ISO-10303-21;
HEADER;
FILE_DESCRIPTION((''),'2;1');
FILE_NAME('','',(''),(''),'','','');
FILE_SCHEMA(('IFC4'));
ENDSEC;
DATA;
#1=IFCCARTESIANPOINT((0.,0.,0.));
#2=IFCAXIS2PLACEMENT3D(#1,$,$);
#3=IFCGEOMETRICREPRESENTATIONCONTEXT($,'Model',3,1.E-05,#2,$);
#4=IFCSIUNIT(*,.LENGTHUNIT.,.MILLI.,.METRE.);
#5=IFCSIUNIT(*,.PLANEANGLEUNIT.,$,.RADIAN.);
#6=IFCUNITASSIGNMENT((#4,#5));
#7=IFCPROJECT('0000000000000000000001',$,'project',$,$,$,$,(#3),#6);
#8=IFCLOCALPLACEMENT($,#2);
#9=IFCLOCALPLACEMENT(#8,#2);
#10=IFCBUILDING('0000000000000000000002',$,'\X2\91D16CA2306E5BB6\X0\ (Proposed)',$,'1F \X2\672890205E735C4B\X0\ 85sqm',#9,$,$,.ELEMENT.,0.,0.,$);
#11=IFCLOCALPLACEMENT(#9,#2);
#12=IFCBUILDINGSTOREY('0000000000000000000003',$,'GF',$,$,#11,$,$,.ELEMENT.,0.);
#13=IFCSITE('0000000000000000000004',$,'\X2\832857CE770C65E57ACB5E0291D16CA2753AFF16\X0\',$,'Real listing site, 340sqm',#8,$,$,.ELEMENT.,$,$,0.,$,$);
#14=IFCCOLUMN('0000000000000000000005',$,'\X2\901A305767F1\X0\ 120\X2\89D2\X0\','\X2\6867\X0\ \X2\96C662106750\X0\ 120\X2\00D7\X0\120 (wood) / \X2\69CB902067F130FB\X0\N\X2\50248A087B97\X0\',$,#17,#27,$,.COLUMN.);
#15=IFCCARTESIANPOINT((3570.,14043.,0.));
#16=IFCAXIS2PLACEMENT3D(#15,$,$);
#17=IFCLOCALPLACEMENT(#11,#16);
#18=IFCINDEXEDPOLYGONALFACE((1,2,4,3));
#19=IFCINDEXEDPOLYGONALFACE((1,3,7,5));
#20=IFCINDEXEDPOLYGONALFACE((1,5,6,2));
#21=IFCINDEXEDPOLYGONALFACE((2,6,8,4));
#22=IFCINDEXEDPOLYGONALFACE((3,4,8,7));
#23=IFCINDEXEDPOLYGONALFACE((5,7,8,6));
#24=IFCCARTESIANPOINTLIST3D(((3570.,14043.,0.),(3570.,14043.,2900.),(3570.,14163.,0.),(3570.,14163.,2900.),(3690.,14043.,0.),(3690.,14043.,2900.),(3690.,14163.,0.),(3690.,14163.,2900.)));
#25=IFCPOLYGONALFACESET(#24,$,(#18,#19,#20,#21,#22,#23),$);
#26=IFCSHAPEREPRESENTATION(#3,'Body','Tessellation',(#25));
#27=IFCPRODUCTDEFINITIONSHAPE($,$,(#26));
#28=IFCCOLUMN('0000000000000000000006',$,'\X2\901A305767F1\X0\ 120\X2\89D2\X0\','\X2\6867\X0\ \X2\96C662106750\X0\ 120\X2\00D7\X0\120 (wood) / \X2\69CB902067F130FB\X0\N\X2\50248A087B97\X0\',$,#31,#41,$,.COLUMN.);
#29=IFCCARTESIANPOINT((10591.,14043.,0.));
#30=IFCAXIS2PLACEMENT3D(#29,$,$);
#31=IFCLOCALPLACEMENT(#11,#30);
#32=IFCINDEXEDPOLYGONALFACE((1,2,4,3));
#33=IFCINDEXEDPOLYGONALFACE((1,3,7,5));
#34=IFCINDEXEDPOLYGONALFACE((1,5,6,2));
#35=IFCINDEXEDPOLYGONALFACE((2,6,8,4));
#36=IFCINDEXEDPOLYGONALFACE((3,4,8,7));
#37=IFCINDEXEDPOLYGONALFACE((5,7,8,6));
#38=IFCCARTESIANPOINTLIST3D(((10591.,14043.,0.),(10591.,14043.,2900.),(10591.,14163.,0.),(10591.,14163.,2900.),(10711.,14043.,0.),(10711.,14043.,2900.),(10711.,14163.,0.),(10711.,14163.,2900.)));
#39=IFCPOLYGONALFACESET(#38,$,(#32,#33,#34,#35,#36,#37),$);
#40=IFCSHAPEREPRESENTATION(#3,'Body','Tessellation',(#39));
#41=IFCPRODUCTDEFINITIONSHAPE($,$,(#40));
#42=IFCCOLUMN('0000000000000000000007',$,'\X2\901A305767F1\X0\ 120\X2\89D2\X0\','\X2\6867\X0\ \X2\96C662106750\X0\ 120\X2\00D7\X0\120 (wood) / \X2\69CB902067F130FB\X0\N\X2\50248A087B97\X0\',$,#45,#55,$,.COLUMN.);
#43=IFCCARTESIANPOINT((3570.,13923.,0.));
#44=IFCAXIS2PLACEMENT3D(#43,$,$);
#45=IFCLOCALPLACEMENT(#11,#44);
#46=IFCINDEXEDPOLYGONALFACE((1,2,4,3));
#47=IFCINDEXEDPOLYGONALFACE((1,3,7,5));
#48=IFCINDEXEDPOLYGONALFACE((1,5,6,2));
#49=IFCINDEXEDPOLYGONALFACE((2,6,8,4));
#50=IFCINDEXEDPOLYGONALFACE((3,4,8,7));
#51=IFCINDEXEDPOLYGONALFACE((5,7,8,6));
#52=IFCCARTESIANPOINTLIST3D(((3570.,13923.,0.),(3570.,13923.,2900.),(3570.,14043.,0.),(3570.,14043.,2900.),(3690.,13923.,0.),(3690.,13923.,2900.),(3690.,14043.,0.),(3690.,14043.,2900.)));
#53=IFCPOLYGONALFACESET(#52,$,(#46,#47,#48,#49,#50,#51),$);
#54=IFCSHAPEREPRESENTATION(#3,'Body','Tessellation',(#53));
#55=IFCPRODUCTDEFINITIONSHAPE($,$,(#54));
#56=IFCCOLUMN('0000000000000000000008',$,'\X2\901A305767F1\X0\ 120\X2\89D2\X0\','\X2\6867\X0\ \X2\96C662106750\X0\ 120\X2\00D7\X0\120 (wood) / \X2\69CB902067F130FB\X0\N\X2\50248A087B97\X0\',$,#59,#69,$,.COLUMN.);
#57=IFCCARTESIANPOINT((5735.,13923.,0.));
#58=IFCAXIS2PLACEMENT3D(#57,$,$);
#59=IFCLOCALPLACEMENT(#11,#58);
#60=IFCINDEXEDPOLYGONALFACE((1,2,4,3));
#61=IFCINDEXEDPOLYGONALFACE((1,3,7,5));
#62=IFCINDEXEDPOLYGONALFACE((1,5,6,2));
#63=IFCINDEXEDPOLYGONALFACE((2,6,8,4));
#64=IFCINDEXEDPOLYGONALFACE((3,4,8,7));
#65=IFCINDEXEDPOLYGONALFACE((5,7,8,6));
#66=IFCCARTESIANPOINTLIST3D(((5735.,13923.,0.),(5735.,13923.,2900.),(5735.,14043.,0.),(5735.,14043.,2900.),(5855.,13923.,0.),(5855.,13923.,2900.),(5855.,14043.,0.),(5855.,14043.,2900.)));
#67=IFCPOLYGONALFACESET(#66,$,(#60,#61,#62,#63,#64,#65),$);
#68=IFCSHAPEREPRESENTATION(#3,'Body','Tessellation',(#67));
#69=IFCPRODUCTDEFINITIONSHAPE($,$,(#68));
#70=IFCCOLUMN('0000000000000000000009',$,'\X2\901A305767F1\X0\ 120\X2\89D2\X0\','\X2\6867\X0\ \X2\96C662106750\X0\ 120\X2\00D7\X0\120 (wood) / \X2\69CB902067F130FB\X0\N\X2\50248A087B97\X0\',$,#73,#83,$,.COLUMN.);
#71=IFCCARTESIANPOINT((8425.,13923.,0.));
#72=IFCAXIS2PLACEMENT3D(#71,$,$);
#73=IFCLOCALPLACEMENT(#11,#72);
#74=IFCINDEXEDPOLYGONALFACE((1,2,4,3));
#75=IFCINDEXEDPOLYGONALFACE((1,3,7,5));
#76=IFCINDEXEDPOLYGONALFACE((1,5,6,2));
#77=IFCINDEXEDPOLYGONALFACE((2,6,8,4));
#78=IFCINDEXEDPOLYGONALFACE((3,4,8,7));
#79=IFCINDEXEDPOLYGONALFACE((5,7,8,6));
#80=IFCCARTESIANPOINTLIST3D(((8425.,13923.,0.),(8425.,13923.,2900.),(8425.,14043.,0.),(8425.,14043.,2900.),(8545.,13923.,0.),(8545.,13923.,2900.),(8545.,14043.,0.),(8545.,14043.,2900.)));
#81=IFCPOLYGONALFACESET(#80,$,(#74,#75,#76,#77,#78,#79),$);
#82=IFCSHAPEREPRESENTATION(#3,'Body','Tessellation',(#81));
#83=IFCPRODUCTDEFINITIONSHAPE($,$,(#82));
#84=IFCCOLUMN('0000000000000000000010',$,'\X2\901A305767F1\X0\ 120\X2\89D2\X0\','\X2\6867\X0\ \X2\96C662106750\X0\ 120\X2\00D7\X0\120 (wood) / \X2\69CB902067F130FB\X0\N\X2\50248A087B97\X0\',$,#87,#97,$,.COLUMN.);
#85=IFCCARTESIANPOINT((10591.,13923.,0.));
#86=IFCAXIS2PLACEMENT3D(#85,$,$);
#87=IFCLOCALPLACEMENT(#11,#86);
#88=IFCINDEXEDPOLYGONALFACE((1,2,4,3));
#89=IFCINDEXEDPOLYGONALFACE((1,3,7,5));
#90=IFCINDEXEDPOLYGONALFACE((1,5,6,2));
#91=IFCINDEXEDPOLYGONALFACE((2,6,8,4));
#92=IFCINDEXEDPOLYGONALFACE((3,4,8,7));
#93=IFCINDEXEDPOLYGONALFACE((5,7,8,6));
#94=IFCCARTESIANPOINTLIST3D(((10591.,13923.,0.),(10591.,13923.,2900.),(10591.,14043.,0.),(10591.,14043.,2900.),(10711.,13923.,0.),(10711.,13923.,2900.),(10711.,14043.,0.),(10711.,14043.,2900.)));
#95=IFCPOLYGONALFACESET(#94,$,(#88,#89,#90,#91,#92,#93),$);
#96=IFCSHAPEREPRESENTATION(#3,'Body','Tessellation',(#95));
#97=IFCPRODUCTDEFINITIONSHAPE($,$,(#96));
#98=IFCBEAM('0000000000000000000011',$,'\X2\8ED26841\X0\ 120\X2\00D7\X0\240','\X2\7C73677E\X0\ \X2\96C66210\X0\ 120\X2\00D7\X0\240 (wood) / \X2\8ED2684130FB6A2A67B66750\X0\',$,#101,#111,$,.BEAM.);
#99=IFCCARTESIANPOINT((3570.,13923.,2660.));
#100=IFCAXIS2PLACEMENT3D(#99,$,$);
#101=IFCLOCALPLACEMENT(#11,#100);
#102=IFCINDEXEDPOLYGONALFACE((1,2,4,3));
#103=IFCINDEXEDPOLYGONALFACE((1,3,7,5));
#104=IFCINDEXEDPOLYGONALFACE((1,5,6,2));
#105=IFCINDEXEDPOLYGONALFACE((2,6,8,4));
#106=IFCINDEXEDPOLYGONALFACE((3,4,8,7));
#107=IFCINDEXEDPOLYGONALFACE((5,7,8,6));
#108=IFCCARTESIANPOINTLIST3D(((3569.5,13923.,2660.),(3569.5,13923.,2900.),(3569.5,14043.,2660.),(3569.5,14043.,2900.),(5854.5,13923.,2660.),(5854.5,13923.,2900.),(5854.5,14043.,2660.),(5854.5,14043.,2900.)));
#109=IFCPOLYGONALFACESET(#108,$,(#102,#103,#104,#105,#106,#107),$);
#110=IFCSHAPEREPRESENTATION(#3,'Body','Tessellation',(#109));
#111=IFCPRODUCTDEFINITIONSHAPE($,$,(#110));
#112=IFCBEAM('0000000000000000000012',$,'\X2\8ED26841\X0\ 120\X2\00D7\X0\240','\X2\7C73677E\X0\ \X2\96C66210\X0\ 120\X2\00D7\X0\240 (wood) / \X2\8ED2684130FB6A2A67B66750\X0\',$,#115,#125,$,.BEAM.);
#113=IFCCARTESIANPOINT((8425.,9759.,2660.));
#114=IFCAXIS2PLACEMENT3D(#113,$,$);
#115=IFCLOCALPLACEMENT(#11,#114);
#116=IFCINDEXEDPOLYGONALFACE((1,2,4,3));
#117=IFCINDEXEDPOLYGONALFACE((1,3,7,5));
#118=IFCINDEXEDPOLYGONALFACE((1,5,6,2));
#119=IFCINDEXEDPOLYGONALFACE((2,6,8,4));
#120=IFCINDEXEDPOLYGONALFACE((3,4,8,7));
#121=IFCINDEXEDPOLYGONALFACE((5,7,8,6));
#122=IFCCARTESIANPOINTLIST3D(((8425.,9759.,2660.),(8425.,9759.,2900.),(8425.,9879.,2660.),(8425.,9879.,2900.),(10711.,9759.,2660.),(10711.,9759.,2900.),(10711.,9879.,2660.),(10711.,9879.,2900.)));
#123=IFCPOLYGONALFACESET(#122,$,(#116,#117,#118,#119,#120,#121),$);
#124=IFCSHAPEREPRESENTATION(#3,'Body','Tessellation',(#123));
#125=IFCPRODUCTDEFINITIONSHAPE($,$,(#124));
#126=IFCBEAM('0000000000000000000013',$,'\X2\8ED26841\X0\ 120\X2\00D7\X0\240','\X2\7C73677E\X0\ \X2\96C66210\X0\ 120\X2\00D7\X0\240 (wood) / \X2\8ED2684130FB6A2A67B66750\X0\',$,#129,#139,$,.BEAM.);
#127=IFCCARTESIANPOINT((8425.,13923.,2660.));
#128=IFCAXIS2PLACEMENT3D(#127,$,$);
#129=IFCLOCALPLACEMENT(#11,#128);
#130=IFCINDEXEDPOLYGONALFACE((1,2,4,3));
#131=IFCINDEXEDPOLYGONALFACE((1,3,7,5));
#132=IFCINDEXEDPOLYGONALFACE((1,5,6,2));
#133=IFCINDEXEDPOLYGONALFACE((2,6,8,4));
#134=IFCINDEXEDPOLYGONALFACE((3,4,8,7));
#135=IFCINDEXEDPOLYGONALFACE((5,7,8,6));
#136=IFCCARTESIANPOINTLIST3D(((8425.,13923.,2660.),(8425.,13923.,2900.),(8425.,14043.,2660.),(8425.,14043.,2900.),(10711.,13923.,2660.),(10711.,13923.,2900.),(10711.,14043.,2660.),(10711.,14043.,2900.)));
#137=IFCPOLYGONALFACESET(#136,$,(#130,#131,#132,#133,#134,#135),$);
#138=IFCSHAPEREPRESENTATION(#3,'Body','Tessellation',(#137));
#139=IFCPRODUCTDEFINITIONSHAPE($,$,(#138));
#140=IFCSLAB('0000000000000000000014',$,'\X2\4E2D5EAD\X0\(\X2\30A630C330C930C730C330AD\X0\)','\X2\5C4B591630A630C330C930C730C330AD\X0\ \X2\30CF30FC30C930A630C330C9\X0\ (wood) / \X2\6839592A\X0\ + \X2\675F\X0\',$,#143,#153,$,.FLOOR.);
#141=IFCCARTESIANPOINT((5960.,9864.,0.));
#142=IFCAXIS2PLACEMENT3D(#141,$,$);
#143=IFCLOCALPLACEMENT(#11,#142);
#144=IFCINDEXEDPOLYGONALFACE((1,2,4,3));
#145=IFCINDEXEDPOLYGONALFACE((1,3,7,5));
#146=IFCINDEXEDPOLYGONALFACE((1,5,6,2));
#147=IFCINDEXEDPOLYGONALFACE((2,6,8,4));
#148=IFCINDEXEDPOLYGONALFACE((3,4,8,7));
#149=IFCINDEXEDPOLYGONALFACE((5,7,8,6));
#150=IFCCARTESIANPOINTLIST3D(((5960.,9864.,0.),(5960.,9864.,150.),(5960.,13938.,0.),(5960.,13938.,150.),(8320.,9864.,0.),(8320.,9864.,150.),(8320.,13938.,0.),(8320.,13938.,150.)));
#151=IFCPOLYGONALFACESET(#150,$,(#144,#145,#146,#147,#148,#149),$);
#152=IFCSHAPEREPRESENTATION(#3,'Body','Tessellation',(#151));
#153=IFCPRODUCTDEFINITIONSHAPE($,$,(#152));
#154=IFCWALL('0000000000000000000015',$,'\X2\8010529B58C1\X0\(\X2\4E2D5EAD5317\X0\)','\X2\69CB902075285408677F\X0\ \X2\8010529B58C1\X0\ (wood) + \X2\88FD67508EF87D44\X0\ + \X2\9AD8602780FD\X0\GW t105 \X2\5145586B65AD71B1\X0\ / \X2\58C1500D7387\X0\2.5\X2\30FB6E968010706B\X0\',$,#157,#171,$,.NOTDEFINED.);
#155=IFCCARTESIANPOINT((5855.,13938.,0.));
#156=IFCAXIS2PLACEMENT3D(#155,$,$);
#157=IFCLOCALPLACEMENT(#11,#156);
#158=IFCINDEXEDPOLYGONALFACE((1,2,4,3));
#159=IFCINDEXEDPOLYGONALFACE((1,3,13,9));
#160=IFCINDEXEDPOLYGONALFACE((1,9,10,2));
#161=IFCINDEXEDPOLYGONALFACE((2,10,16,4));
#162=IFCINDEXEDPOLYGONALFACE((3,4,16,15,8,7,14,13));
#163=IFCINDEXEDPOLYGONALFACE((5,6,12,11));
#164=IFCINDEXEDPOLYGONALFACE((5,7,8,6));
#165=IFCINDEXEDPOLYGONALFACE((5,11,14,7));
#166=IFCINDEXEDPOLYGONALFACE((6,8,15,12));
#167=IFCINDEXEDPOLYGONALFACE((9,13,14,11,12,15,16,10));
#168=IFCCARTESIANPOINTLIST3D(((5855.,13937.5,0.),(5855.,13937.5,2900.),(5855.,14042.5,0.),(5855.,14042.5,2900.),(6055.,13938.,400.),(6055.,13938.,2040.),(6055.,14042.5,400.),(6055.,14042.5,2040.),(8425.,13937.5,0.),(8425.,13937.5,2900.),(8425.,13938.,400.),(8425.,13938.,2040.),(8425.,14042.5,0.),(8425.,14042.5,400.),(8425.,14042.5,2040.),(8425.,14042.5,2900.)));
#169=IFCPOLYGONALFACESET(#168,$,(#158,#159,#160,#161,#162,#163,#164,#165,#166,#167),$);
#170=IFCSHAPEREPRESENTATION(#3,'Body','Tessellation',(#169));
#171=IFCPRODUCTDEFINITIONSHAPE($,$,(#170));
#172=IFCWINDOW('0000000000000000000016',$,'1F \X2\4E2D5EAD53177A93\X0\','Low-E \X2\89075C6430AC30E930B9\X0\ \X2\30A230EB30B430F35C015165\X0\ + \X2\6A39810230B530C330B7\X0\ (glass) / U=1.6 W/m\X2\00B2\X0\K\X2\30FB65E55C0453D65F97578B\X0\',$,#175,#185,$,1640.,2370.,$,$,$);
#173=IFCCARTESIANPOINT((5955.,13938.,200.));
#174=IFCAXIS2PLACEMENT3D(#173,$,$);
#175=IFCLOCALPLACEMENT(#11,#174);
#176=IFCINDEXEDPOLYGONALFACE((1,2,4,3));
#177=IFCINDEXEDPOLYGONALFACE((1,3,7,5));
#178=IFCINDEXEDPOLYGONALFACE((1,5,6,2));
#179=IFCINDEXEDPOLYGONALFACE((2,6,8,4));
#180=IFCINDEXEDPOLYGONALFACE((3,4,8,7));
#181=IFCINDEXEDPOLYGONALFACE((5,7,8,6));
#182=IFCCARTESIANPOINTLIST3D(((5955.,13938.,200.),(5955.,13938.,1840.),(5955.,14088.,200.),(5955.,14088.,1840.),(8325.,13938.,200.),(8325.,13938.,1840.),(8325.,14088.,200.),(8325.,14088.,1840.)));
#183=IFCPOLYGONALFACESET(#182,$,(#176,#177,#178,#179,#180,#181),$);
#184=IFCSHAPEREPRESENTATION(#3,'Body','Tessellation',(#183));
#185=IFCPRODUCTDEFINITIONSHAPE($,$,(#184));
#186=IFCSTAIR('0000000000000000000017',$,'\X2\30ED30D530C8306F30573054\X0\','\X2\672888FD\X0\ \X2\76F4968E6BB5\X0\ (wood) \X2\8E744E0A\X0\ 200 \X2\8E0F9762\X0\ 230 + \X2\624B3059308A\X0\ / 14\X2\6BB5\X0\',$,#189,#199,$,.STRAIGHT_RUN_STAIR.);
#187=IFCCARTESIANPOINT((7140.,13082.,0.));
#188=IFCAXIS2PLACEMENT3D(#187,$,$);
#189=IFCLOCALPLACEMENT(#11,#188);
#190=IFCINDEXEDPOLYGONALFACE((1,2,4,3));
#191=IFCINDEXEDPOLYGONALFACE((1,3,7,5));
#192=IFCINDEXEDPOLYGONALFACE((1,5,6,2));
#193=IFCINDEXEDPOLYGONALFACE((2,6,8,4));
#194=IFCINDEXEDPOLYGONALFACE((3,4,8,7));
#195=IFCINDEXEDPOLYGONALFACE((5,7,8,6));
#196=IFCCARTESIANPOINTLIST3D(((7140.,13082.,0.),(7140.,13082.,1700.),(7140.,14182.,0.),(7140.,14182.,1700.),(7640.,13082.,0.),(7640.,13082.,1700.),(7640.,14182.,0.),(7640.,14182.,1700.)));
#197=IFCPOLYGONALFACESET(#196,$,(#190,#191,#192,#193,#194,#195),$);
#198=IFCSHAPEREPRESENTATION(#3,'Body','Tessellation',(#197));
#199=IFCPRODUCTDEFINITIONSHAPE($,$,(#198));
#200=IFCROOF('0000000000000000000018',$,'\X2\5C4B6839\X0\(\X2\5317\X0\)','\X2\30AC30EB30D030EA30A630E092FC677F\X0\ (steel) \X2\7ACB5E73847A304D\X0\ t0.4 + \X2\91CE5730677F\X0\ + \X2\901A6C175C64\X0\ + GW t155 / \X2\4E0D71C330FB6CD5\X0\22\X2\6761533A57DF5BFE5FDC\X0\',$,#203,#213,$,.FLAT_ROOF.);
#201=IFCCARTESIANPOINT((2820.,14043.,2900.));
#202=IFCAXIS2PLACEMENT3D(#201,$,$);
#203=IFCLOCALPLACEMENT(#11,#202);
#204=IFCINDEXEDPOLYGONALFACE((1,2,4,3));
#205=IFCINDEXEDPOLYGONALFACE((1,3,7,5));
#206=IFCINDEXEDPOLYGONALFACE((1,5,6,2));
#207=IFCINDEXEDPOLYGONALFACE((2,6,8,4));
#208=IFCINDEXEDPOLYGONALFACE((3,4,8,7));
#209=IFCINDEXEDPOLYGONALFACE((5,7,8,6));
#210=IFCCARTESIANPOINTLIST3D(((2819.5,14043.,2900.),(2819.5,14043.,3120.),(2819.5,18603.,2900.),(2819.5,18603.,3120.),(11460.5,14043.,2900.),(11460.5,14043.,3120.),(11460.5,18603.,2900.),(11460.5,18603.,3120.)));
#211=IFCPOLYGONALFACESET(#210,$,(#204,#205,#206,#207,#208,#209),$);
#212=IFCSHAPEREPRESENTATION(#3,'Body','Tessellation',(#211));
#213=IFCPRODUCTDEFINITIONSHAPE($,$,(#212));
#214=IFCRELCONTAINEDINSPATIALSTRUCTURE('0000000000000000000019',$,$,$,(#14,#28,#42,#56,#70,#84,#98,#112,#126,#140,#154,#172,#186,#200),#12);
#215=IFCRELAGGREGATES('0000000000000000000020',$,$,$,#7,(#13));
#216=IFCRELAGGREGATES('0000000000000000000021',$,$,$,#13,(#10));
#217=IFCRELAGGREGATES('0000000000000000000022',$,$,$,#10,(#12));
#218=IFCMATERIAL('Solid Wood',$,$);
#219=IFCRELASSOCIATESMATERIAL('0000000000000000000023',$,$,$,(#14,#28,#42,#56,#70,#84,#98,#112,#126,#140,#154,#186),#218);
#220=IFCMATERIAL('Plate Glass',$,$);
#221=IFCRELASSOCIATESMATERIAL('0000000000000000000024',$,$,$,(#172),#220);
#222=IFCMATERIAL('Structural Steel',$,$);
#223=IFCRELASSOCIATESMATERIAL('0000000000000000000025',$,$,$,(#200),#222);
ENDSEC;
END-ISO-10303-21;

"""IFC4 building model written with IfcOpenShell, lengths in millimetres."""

from ifc_helpers import new_model, si_unit, frame, frame_2d, origin, place, context, project, spatial, rectangle, extrude, material, element, fill, save


model = new_model("IFC4")

# Units and contexts
model_context = context("Model", 3, precision=1e-05, world=origin())
ifc_project = project(units=[si_unit("LENGTHUNIT", "METRE", prefix="MILLI"), si_unit("PLANEANGLEUNIT", "RADIAN")], contexts=[model_context])

# Site, building, storey
site_placement = place(None, origin())
site = spatial("IfcSite", under=ifc_project, at=site_placement, Name="茨城県日立市金沢町６", ObjectType="Real listing site, 340sqm", CompositionType="ELEMENT", RefElevation=0.0)
building_placement = place(site_placement, origin())
building = spatial("IfcBuilding", under=site, at=building_placement, Name="金沢の家 (Proposed)", ObjectType="1F 木造平屋 85sqm", CompositionType="ELEMENT", ElevationOfRefHeight=0.0, ElevationOfTerrain=0.0)
storey_placement = place(building_placement, origin())
storey = spatial("IfcBuildingStorey", under=building, at=storey_placement, Name="GF", CompositionType="ELEMENT", Elevation=0.0)

# Columns
ifc_material_1 = material(Name="Solid Wood")
column_1_placement = place(storey_placement, frame((3570.0, 14043.0, 0.0)))
element("IfcColumn", 1, at=column_1_placement, inside=storey, material=ifc_material_1, Name="通し柱 120角", Description="桧 集成材 120×120 (wood) / 構造柱・N値計算", PredefinedType="COLUMN", context=model_context, shape_type="SweptSolid", body=[
    extrude(rectangle(XDim=120.0, YDim=120.0, at=frame_2d((60.0, 60.0))), frame((3570.0, 14043.0, 0.0)), (0.0, 0.0, 1.0), 2900.0),
])
column_2_placement = place(storey_placement, frame((10591.0, 14043.0, 0.0)))
element("IfcColumn", 2, at=column_2_placement, inside=storey, material=ifc_material_1, Name="通し柱 120角", Description="桧 集成材 120×120 (wood) / 構造柱・N値計算", PredefinedType="COLUMN", context=model_context, shape_type="SweptSolid", body=[
    extrude(rectangle(XDim=120.0, YDim=120.0, at=frame_2d((60.0, 60.0))), frame((10591.0, 14043.0, 0.0)), (0.0, 0.0, 1.0), 2900.0),
])
column_3_placement = place(storey_placement, frame((3570.0, 13923.0, 0.0)))
element("IfcColumn", 3, at=column_3_placement, inside=storey, material=ifc_material_1, Name="通し柱 120角", Description="桧 集成材 120×120 (wood) / 構造柱・N値計算", PredefinedType="COLUMN", context=model_context, shape_type="SweptSolid", body=[
    extrude(rectangle(XDim=120.0, YDim=120.0, at=frame_2d((60.0, 60.0))), frame((3570.0, 13923.0, 0.0)), (0.0, 0.0, 1.0), 2900.0),
])
column_4_placement = place(storey_placement, frame((5735.0, 13923.0, 0.0)))
element("IfcColumn", 4, at=column_4_placement, inside=storey, material=ifc_material_1, Name="通し柱 120角", Description="桧 集成材 120×120 (wood) / 構造柱・N値計算", PredefinedType="COLUMN", context=model_context, shape_type="SweptSolid", body=[
    extrude(rectangle(XDim=120.0, YDim=120.0, at=frame_2d((60.0, 60.0))), frame((5735.0, 13923.0, 0.0)), (0.0, 0.0, 1.0), 2900.0),
])
column_5_placement = place(storey_placement, frame((8425.0, 13923.0, 0.0)))
element("IfcColumn", 5, at=column_5_placement, inside=storey, material=ifc_material_1, Name="通し柱 120角", Description="桧 集成材 120×120 (wood) / 構造柱・N値計算", PredefinedType="COLUMN", context=model_context, shape_type="SweptSolid", body=[
    extrude(rectangle(XDim=120.0, YDim=120.0, at=frame_2d((60.0, 60.0))), frame((8425.0, 13923.0, 0.0)), (0.0, 0.0, 1.0), 2900.0),
])
column_6_placement = place(storey_placement, frame((10591.0, 13923.0, 0.0)))
element("IfcColumn", 6, at=column_6_placement, inside=storey, material=ifc_material_1, Name="通し柱 120角", Description="桧 集成材 120×120 (wood) / 構造柱・N値計算", PredefinedType="COLUMN", context=model_context, shape_type="SweptSolid", body=[
    extrude(rectangle(XDim=120.0, YDim=120.0, at=frame_2d((60.0, 60.0))), frame((10591.0, 13923.0, 0.0)), (0.0, 0.0, 1.0), 2900.0),
])

# Beams
beam_1_placement = place(storey_placement, frame((3570.0, 13923.0, 2660.0)))
element("IfcBeam", 7, at=beam_1_placement, inside=storey, material=ifc_material_1, Name="軒桁 120×240", Description="米松 集成 120×240 (wood) / 軒桁・横架材", PredefinedType="BEAM", context=model_context, shape_type="SweptSolid", body=[
    extrude(rectangle(XDim=2285.0, YDim=120.0, at=frame_2d((1142.0, 60.0))), frame((3570.0, 13923.0, 2660.0)), (0.0, 0.0, 1.0), 240.0),
])
beam_2_placement = place(storey_placement, frame((8425.0, 9759.0, 2660.0)))
element("IfcBeam", 8, at=beam_2_placement, inside=storey, material=ifc_material_1, Name="軒桁 120×240", Description="米松 集成 120×240 (wood) / 軒桁・横架材", PredefinedType="BEAM", context=model_context, shape_type="SweptSolid", body=[
    extrude(rectangle(XDim=2286.0, YDim=120.0, at=frame_2d((1143.0, 60.0))), frame((8425.0, 9759.0, 2660.0)), (0.0, 0.0, 1.0), 240.0),
])
beam_3_placement = place(storey_placement, frame((8425.0, 13923.0, 2660.0)))
element("IfcBeam", 9, at=beam_3_placement, inside=storey, material=ifc_material_1, Name="軒桁 120×240", Description="米松 集成 120×240 (wood) / 軒桁・横架材", PredefinedType="BEAM", context=model_context, shape_type="SweptSolid", body=[
    extrude(rectangle(XDim=2286.0, YDim=120.0, at=frame_2d((1143.0, 60.0))), frame((8425.0, 13923.0, 2660.0)), (0.0, 0.0, 1.0), 240.0),
])

# Slab
slab_1_placement = place(storey_placement, frame((5960.0, 9864.0, 0.0)))
element("IfcSlab", 10, at=slab_1_placement, inside=storey, material=ifc_material_1, Name="中庭(ウッドデッキ)", Description="屋外ウッドデッキ ハードウッド (wood) / 根太 + 束", PredefinedType="FLOOR", context=model_context, shape_type="SweptSolid", body=[
    extrude(rectangle(XDim=2360.0, YDim=4074.0, at=frame_2d((1180.0, 2037.0))), frame((5960.0, 9864.0, 0.0)), (0.0, 0.0, 1.0), 150.0),
])

# Wall, opening, window
wall_placement = place(storey_placement, frame((5855.0, 13938.0, 0.0)))
wall = element("IfcWall", 11, at=wall_placement, inside=storey, material=ifc_material_1, Name="耐力壁(中庭北)", Description="構造用合板 耐力壁 (wood) + 製材軸組 + 高性能GW t105 充填断熱 / 壁倍率2.5・準耐火", PredefinedType="NOTDEFINED", context=model_context, shape_type="SweptSolid", body=[
    extrude(rectangle(XDim=2570.0, YDim=105.0, at=frame_2d((1285.0, 52.0))), frame((5855.0, 13938.0, 0.0)), (0.0, 0.0, 1.0), 2900.0),
])
opening_placement = place(storey_placement, frame((5955.0, 13938.0, 200.0)))
opening = element("IfcOpeningElement", 12, at=opening_placement, cuts=wall, PredefinedType="NOTDEFINED", context=model_context, shape_type="SweptSolid", body=[
    extrude(rectangle(XDim=2370.0, YDim=150.0, at=frame_2d((1185.0, 75.0))), frame((5955.0, 13938.0, 200.0)), (0.0, 0.0, 1.0), 1640.0),
])
ifc_material_2 = material(Name="Plate Glass")
window_placement = place(storey_placement, frame((5955.0, 13938.0, 200.0)))
window = element("IfcWindow", 13, at=window_placement, inside=storey, material=ifc_material_2, Name="1F 中庭北窓", Description="Low-E 複層ガラス アルゴン封入 + 樹脂サッシ (glass) / U=1.6 W/m²K・日射取得型", OverallHeight=1640.0, OverallWidth=2370.0, context=model_context, shape_type="SweptSolid", body=[
    extrude(rectangle(XDim=2370.0, YDim=150.0, at=frame_2d((1185.0, 75.0))), frame((5955.0, 13938.0, 200.0)), (0.0, 0.0, 1.0), 1640.0),
])
fill(opening, window)

# Stair
stair_placement = place(storey_placement, frame((7140.0, 13082.0, 0.0)))
element("IfcStair", 14, at=stair_placement, inside=storey, material=ifc_material_1, Name="ロフトはしご", Description="木製 直階段 (wood) 蹴上 200 踏面 230 + 手すり / 14段", PredefinedType="STRAIGHT_RUN_STAIR", context=model_context, shape_type="SweptSolid", body=[
    extrude(rectangle(XDim=500.0, YDim=1100.0, at=frame_2d((250.0, 550.0))), frame((7140.0, 13082.0, 0.0)), (0.0, 0.0, 1.0), 1700.0),
])

# Roof
ifc_material_3 = material(Name="Structural Steel")
roof_placement = place(storey_placement, frame((2820.0, 14043.0, 2900.0)))
element("IfcRoof", 15, at=roof_placement, inside=storey, material=ifc_material_3, Name="屋根(北)", Description="ガルバリウム鋼板 (steel) 立平葺き t0.4 + 野地板 + 通気層 + GW t155 / 不燃・法22条区域対応", PredefinedType="FLAT_ROOF", context=model_context, shape_type="SweptSolid", body=[
    extrude(rectangle(XDim=8641.0, YDim=4560.0, at=frame_2d((4320.0, 2280.0))), frame((2820.0, 14043.0, 2900.0)), (0.0, 0.0, 1.0), 220.0),
])

save(model, "model.ifc")
